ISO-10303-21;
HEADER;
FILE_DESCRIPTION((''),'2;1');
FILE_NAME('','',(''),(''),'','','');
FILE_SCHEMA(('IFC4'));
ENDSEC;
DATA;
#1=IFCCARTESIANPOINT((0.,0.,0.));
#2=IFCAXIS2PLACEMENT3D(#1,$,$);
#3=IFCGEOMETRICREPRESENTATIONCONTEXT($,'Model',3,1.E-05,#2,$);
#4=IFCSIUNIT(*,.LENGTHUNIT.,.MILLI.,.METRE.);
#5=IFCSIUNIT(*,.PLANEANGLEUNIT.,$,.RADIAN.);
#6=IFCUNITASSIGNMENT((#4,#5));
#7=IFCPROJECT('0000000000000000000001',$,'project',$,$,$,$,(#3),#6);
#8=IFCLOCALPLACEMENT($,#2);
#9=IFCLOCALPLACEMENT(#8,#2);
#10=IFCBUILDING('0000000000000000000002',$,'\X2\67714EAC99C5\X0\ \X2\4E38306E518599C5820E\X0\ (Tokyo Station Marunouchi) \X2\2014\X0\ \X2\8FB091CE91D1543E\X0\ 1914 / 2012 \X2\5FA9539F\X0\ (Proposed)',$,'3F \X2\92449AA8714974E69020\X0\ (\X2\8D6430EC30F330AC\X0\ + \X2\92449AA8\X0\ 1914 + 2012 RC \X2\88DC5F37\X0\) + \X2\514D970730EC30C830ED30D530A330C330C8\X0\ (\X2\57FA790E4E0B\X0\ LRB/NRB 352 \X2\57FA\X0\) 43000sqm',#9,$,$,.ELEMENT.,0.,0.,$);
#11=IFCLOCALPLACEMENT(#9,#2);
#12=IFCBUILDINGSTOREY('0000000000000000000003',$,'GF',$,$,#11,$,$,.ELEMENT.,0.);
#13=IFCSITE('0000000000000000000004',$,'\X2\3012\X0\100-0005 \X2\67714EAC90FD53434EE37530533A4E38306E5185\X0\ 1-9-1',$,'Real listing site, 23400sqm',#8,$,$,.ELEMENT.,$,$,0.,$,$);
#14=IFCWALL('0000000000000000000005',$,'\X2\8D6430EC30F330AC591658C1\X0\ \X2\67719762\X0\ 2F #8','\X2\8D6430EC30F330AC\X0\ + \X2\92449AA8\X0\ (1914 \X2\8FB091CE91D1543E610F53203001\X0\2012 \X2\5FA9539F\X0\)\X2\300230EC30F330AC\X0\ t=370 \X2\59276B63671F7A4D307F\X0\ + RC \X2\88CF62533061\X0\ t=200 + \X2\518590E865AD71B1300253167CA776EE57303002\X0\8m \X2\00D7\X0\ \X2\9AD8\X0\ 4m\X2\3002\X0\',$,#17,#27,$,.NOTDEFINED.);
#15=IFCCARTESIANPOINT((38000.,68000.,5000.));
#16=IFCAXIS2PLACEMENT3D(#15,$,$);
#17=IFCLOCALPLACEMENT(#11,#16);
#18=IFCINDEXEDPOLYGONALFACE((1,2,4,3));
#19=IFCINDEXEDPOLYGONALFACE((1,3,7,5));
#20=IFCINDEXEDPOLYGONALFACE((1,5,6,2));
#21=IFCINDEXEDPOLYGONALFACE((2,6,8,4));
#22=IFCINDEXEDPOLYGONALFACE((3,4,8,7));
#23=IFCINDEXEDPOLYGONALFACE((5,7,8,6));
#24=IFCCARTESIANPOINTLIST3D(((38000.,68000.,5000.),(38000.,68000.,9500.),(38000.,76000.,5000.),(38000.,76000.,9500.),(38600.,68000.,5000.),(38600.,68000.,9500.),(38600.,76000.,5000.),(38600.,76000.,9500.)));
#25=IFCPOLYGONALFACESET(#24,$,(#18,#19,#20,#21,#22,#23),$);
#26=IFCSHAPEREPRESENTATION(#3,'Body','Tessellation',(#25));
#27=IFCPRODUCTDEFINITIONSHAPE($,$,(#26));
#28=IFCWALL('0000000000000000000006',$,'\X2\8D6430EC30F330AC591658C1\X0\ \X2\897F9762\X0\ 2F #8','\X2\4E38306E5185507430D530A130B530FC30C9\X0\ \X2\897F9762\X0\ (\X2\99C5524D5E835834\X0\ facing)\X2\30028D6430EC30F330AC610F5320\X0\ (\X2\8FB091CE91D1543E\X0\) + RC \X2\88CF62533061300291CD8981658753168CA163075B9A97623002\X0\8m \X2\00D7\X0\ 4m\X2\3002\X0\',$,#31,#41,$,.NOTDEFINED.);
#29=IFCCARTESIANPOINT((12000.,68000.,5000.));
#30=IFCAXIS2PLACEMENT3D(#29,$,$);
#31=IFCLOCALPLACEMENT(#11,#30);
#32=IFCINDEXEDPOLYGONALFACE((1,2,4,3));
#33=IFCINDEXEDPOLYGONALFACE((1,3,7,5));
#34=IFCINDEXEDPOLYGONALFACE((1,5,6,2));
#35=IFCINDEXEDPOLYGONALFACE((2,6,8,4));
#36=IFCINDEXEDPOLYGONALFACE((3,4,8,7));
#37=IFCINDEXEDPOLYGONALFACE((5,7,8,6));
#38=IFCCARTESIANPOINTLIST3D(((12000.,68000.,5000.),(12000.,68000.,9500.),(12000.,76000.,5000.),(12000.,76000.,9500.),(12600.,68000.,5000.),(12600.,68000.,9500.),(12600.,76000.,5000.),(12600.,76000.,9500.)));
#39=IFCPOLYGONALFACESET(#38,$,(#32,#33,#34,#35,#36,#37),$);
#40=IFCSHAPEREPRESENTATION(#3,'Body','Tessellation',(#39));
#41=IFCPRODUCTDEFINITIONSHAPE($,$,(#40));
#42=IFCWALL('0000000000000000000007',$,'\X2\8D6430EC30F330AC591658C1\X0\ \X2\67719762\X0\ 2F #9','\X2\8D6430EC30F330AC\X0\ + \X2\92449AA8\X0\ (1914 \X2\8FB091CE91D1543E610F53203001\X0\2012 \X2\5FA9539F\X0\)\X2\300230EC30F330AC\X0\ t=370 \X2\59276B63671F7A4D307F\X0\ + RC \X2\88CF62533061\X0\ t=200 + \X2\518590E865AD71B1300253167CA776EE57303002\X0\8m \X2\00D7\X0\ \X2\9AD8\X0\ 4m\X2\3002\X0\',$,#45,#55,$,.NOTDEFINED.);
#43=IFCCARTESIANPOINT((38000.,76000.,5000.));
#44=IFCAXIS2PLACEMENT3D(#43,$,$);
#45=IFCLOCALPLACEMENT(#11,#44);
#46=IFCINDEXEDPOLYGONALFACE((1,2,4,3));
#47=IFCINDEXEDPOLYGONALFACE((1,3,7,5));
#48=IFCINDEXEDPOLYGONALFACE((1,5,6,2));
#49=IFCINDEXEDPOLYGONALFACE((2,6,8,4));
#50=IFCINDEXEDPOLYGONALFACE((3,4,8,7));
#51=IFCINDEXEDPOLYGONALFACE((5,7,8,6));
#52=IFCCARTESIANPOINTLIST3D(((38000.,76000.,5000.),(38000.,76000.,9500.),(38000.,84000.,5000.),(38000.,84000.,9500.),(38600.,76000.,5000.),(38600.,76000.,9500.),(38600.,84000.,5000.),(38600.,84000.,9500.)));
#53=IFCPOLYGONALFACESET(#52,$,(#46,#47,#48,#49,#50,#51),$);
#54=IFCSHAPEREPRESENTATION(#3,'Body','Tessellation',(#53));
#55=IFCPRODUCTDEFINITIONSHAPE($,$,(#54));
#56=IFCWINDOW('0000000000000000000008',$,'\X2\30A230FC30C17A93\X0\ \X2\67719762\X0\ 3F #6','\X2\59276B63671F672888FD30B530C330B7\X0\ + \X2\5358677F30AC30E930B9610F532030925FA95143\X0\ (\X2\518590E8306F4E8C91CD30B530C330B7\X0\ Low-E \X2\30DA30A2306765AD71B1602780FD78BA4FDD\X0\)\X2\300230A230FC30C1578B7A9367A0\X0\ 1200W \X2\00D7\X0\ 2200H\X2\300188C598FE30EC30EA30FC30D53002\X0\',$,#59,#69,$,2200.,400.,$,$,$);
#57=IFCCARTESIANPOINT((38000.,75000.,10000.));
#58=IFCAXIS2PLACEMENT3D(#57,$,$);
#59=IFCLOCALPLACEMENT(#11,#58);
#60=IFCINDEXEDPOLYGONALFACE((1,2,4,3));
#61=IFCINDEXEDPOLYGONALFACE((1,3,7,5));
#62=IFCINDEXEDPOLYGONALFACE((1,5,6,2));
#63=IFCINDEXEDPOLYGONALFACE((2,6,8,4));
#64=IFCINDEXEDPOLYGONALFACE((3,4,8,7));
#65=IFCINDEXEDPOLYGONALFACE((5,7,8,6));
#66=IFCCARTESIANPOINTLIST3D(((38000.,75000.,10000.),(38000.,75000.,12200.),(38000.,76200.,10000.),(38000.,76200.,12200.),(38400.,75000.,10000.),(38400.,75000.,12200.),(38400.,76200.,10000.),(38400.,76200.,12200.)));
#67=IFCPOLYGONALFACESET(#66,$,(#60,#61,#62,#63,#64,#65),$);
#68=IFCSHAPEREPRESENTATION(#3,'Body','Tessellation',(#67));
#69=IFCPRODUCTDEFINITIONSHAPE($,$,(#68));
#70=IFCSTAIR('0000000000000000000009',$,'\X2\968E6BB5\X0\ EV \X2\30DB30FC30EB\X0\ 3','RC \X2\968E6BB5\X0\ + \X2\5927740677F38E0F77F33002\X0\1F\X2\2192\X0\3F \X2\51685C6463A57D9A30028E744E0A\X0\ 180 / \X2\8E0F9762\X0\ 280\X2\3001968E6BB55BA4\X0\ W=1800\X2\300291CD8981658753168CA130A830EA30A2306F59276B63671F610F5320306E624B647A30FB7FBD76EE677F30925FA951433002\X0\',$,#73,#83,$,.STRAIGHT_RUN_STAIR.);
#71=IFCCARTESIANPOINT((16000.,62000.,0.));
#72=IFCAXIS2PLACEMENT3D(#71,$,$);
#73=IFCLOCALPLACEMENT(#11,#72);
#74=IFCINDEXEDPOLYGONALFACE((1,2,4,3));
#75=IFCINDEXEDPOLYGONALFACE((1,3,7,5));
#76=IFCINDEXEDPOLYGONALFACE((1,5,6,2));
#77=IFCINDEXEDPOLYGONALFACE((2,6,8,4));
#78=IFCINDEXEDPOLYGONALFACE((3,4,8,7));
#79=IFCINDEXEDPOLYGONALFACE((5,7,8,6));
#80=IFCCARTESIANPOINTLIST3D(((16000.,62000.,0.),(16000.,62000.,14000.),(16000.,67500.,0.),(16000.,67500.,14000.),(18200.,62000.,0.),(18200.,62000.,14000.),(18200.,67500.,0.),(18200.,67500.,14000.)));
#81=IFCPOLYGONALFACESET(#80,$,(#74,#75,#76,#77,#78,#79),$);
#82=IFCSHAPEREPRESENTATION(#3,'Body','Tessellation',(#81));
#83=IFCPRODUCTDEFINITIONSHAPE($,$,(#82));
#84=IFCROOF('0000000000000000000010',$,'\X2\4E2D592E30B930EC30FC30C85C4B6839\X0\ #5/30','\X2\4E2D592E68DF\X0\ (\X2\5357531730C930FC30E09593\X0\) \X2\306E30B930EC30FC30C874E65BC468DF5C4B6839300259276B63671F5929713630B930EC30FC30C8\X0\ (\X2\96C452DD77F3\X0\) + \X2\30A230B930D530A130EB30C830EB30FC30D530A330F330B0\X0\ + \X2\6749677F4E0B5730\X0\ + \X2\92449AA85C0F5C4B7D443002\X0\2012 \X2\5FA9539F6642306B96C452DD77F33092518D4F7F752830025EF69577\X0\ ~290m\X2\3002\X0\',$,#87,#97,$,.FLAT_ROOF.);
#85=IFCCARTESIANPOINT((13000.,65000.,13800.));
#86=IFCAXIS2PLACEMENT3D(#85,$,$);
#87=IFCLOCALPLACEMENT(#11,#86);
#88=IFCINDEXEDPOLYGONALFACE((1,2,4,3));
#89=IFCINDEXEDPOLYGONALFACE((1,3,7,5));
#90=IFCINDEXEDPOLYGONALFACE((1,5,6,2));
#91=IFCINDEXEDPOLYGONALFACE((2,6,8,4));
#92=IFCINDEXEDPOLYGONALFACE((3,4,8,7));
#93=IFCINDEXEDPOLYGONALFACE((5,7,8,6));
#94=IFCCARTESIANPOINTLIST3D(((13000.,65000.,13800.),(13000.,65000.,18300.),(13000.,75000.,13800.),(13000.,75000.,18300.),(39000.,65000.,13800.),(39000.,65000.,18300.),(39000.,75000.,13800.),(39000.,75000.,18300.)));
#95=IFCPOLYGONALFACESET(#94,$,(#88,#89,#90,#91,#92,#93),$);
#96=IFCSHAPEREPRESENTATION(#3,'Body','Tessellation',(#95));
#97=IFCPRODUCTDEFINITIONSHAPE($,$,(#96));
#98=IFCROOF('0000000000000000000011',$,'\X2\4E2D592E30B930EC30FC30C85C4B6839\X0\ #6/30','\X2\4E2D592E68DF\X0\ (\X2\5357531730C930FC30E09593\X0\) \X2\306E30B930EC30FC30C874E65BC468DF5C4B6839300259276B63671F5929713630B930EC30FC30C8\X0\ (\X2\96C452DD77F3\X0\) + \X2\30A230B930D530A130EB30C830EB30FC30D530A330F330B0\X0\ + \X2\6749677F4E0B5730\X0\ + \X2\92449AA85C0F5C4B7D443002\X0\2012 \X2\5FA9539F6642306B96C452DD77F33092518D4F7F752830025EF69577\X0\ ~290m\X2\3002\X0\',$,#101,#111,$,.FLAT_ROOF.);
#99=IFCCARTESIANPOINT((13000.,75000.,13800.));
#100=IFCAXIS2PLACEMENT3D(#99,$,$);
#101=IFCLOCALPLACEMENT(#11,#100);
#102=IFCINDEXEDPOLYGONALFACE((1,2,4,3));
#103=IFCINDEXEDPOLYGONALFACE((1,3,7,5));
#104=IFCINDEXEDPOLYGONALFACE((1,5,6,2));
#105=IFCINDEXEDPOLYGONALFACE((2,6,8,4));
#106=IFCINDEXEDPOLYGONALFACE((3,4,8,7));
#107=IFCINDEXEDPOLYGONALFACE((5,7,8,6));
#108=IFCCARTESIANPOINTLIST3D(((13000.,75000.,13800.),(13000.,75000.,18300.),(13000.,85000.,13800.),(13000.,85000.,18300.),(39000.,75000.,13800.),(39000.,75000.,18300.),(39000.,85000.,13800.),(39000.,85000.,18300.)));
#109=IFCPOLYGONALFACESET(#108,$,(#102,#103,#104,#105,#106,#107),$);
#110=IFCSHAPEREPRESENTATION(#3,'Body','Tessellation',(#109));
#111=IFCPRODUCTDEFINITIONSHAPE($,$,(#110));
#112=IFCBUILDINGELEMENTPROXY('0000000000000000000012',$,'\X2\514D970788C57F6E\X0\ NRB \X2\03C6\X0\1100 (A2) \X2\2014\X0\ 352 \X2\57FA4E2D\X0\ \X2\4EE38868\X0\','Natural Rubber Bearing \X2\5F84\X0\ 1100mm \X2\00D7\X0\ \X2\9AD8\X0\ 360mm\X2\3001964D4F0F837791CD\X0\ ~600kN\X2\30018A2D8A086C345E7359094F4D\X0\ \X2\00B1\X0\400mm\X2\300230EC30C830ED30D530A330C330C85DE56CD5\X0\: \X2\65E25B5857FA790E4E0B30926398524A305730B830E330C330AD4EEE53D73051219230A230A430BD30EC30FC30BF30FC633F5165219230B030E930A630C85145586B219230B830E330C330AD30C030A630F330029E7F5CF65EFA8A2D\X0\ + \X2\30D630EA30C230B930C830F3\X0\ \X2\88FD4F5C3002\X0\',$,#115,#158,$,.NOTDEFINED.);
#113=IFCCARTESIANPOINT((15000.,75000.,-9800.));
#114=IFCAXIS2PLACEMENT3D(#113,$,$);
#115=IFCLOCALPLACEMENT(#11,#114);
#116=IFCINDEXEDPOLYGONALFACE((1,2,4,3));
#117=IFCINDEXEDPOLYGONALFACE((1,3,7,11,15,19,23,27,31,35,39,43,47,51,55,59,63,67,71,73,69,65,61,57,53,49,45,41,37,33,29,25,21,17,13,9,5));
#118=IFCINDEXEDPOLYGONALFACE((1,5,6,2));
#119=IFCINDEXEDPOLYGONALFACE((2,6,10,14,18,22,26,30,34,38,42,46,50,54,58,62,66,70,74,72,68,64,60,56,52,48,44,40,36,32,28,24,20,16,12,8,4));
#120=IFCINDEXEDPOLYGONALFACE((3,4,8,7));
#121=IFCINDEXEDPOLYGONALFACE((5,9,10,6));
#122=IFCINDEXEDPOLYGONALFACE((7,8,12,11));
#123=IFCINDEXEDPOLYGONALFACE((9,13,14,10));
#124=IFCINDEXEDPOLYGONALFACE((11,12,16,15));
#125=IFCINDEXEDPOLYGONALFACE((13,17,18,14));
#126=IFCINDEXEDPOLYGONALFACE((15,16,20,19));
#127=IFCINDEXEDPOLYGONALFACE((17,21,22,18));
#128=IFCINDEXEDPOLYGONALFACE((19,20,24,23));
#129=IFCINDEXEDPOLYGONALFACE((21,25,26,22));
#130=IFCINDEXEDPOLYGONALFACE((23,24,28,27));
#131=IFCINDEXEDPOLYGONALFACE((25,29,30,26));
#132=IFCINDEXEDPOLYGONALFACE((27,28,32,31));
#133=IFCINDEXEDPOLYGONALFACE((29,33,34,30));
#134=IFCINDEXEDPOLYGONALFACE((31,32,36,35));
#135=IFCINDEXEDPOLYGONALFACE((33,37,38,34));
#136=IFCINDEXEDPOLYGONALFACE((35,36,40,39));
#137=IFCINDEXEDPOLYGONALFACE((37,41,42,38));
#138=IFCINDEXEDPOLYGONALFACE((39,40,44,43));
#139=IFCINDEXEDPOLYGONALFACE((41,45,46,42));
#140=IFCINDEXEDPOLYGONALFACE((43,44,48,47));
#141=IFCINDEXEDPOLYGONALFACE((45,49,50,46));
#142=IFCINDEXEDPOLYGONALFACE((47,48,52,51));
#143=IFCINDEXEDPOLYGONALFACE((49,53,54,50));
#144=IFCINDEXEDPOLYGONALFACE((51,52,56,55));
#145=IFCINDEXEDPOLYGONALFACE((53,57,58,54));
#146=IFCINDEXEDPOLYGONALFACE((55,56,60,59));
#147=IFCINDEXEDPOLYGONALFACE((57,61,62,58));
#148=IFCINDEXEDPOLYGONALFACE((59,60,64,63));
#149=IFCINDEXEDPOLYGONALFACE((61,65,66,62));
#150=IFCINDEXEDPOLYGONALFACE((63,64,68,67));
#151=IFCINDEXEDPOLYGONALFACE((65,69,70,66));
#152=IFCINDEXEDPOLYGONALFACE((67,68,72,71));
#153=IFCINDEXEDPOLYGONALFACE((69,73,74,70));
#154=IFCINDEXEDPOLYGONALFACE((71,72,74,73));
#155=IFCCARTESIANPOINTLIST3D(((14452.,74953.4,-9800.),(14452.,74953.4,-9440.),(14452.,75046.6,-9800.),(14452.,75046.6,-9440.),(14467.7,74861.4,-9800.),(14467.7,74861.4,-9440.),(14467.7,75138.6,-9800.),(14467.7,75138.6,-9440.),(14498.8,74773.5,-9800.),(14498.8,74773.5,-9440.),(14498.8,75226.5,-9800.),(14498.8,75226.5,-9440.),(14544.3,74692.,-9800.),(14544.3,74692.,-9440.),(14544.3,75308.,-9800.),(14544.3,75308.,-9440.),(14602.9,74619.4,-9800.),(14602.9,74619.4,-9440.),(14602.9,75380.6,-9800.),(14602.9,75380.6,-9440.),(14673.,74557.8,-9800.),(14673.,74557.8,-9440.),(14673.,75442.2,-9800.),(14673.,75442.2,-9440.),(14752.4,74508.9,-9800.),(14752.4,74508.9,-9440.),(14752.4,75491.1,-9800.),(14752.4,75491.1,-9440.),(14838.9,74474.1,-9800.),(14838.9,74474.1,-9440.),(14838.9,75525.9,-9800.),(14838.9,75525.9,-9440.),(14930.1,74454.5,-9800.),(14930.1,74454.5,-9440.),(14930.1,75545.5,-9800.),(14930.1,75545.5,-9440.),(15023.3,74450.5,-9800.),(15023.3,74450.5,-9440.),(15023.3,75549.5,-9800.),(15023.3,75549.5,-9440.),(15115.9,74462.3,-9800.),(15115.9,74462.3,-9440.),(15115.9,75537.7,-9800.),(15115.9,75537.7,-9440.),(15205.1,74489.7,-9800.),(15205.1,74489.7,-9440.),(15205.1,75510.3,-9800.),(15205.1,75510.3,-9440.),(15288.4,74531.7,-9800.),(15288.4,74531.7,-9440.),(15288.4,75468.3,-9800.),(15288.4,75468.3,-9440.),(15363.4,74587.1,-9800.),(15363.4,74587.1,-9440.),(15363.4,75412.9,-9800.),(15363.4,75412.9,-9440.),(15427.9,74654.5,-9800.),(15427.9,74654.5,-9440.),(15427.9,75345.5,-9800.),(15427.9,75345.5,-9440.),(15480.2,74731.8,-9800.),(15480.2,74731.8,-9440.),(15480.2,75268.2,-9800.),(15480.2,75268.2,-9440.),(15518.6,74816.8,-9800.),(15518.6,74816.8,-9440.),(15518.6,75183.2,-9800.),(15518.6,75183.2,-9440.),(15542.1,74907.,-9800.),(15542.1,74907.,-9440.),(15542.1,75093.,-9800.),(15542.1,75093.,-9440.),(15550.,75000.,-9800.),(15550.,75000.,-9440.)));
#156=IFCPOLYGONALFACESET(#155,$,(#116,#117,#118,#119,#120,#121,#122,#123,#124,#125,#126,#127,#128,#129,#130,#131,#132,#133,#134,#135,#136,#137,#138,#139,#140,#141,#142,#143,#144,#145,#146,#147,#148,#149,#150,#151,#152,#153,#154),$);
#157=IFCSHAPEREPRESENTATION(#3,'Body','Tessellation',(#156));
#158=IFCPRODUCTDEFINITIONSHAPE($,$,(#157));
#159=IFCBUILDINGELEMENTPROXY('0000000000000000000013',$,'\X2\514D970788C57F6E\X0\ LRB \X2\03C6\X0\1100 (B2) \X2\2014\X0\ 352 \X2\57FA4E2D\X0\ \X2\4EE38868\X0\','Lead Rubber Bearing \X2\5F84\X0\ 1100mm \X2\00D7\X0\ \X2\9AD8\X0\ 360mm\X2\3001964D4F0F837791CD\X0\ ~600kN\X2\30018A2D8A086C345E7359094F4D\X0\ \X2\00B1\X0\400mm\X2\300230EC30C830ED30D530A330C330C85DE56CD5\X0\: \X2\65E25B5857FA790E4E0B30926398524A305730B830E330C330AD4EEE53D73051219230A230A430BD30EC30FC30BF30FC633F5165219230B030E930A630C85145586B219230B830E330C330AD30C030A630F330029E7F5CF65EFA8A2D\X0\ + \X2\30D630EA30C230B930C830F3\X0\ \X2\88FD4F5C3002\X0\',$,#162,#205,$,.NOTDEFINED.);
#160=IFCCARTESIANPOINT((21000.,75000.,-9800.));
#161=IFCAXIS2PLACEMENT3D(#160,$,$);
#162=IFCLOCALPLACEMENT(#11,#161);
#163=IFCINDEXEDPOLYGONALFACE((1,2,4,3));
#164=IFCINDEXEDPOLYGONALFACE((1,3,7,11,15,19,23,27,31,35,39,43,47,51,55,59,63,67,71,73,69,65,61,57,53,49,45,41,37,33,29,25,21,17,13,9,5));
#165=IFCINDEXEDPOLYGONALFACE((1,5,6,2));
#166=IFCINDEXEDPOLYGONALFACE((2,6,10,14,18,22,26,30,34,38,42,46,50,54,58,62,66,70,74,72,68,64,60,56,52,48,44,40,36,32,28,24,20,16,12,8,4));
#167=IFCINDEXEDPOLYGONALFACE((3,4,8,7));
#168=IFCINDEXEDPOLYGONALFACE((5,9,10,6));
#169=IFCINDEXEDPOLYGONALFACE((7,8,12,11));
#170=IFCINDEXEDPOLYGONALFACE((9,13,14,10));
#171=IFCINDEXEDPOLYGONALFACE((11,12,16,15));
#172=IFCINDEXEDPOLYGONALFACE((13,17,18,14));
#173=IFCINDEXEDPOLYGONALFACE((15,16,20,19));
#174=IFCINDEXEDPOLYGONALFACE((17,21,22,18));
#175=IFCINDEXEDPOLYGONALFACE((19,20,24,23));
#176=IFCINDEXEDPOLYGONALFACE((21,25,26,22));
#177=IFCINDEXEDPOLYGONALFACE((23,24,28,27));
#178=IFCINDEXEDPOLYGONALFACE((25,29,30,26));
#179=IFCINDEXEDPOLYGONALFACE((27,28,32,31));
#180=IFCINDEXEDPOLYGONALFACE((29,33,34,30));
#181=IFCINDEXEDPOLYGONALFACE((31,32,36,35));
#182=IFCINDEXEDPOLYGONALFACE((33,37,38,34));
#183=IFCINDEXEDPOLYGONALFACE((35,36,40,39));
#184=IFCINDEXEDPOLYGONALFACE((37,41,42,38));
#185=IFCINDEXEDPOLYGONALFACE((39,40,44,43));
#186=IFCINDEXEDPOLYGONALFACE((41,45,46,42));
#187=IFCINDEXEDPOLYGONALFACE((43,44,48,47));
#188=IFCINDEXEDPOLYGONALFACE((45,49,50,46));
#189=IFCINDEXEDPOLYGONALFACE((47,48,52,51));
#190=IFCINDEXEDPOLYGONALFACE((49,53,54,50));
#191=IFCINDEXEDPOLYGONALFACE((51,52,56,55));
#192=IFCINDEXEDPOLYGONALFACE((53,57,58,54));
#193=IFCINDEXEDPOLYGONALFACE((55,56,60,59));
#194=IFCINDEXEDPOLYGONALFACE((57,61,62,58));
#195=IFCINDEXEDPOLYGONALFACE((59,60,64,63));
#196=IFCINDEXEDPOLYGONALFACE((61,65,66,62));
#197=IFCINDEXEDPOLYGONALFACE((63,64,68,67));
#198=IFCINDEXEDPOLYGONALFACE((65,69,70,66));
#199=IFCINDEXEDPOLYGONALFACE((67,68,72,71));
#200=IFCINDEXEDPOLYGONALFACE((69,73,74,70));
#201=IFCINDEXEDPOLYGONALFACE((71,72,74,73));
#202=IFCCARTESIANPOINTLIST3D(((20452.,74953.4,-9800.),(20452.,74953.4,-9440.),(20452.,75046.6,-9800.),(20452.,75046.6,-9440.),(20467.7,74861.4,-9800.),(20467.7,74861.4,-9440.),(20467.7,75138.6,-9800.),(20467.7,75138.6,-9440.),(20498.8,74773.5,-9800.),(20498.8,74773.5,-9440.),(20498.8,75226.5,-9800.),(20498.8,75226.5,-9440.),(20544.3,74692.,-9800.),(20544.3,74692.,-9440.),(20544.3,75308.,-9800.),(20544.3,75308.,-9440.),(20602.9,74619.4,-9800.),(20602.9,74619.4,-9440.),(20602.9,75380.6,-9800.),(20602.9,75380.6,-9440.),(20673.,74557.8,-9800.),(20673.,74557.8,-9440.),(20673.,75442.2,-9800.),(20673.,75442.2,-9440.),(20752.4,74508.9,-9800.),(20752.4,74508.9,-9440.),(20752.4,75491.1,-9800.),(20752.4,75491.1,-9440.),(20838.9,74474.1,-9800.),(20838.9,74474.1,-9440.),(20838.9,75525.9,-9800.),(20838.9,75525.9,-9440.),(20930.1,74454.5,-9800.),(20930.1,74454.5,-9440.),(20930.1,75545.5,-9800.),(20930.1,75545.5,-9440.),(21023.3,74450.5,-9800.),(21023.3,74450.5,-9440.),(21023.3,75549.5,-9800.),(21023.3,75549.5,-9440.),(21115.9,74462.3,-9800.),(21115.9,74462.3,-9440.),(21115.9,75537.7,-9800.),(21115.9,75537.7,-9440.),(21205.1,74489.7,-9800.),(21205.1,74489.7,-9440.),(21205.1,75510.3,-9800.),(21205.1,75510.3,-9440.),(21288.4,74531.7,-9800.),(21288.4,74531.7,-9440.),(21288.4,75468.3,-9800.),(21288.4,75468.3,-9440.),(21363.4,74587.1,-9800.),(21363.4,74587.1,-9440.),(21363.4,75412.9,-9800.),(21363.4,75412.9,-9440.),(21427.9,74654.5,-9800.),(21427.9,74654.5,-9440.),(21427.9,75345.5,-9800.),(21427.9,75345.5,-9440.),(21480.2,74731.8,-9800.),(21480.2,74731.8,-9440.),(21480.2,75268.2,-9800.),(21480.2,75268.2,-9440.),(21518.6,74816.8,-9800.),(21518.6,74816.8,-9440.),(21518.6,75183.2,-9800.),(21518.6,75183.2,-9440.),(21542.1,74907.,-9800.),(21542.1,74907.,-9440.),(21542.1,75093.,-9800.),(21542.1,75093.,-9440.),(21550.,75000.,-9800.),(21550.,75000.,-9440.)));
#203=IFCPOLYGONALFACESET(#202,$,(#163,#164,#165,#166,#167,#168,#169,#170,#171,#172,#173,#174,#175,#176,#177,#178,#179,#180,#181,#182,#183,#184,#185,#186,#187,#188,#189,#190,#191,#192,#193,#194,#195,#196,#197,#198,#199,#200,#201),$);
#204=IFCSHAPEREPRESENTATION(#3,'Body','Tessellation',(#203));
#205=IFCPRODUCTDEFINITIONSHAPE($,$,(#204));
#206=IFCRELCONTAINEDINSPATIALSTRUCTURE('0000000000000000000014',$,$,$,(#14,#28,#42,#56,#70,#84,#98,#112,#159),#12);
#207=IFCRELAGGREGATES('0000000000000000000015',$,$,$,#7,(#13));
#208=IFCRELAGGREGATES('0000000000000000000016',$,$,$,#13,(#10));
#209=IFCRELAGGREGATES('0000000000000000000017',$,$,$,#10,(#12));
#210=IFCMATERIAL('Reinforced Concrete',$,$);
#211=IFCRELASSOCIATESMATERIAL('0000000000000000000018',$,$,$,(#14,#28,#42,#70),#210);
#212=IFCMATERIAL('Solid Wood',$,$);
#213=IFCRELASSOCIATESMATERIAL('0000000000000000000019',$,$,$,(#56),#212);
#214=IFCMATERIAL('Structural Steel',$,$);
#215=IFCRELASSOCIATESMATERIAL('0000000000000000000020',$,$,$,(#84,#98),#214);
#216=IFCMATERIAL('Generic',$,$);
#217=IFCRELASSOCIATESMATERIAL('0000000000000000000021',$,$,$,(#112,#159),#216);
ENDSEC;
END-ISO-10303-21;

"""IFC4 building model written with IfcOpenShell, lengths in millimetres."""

from ifc_helpers import new_model, si_unit, frame, frame_2d, origin, origin_2d, place, context, project, spatial, rectangle, circle, extrude, material, element, save


model = new_model("IFC4")

# Units and contexts
model_context = context("Model", 3, precision=1e-05, world=origin())
ifc_project = project(units=[si_unit("LENGTHUNIT", "METRE", prefix="MILLI"), si_unit("PLANEANGLEUNIT", "RADIAN")], contexts=[model_context])

# Site, building, storey
site_placement = place(None, origin())
site = spatial("IfcSite", under=ifc_project, at=site_placement, Name="〒100-0005 東京都千代田区丸の内 1-9-1", ObjectType="Real listing site, 23400sqm", CompositionType="ELEMENT", RefElevation=0.0)
building_placement = place(site_placement, origin())
building = spatial("IfcBuilding", under=site, at=building_placement, Name="東京駅 丸の内駅舎 (Tokyo Station Marunouchi) — 辰野金吾 1914 / 2012 復原 (Proposed)", ObjectType="3F 鉄骨煉瓦造 (赤レンガ + 鉄骨 1914 + 2012 RC 補強) + 免震レトロフィット (基礎下 LRB/NRB 352 基) 43000sqm", CompositionType="ELEMENT", ElevationOfRefHeight=0.0, ElevationOfTerrain=0.0)
storey_placement = place(building_placement, origin())
storey = spatial("IfcBuildingStorey", under=building, at=storey_placement, Name="GF", CompositionType="ELEMENT", Elevation=0.0)

# Shared definitions
ifc_material_1 = material(Name="Reinforced Concrete")

# Shared definitions
ifc_material_2 = material(Name="Structural Steel")

# Shared definitions
ifc_material_3 = material(Name="Solid Wood")

# Walls
wall_1_placement = place(storey_placement, frame((38000.0, 68000.0, 5000.0)))
element("IfcWall", 1, at=wall_1_placement, inside=storey, material=ifc_material_1, Name="赤レンガ外壁 東面 2F #8", Description="赤レンガ + 鉄骨 (1914 辰野金吾意匠、2012 復原)。レンガ t=370 大正期積み + RC 裏打ち t=200 + 内部断熱。化粧目地。8m × 高 4m。", PredefinedType="NOTDEFINED", context=model_context, shape_type="SweptSolid", body=[
    extrude(rectangle(XDim=600.0, YDim=8000.0, at=frame_2d((300.0, 4000.0))), frame((38000.0, 68000.0, 5000.0)), (0.0, 0.0, 1.0), 4500.0),
])
wall_2_placement = place(storey_placement, frame((12000.0, 68000.0, 5000.0)))
element("IfcWall", 2, at=wall_2_placement, inside=storey, material=ifc_material_1, Name="赤レンガ外壁 西面 2F #8", Description="丸の内側ファサード 西面 (駅前広場 facing)。赤レンガ意匠 (辰野金吾) + RC 裏打ち。重要文化財指定面。8m × 4m。", PredefinedType="NOTDEFINED", context=model_context, shape_type="SweptSolid", body=[
    extrude(rectangle(XDim=600.0, YDim=8000.0, at=frame_2d((300.0, 4000.0))), frame((12000.0, 68000.0, 5000.0)), (0.0, 0.0, 1.0), 4500.0),
])
wall_3_placement = place(storey_placement, frame((38000.0, 76000.0, 5000.0)))
element("IfcWall", 3, at=wall_3_placement, inside=storey, material=ifc_material_1, Name="赤レンガ外壁 東面 2F #9", Description="赤レンガ + 鉄骨 (1914 辰野金吾意匠、2012 復原)。レンガ t=370 大正期積み + RC 裏打ち t=200 + 内部断熱。化粧目地。8m × 高 4m。", PredefinedType="NOTDEFINED", context=model_context, shape_type="SweptSolid", body=[
    extrude(rectangle(XDim=600.0, YDim=8000.0, at=frame_2d((300.0, 4000.0))), frame((38000.0, 76000.0, 5000.0)), (0.0, 0.0, 1.0), 4500.0),
])

# Window
window_1_placement = place(storey_placement, frame((38000.0, 75000.0, 10000.0)))
element("IfcWindow", 4, at=window_1_placement, inside=storey, material=ifc_material_3, Name="アーチ窓 東面 3F #6", Description="大正期木製サッシ + 単板ガラス意匠を復元 (内部は二重サッシ Low-E ペアで断熱性能確保)。アーチ型窓枠 1200W × 2200H、装飾レリーフ。", OverallHeight=2200.0, OverallWidth=400.0, context=model_context, shape_type="SweptSolid", body=[
    extrude(rectangle(XDim=400.0, YDim=1200.0, at=frame_2d((200.0, 600.0))), frame((38000.0, 75000.0, 10000.0)), (0.0, 0.0, 1.0), 2200.0),
])

# Stair
stair_placement = place(storey_placement, frame((16000.0, 62000.0, 0.0)))
element("IfcStair", 5, at=stair_placement, inside=storey, material=ifc_material_1, Name="階段 EV ホール 3", Description="RC 階段 + 大理石踏石。1F→3F 全層接続。蹴上 180 / 踏面 280、階段室 W=1800。重要文化財エリアは大正期意匠の手摺・羽目板を復元。", PredefinedType="STRAIGHT_RUN_STAIR", context=model_context, shape_type="SweptSolid", body=[
    extrude(rectangle(XDim=2200.0, YDim=5500.0, at=frame_2d((1100.0, 2750.0))), frame((16000.0, 62000.0, 0.0)), (0.0, 0.0, 1.0), 14000.0),
])

# Roofs
roof_1_placement = place(storey_placement, frame((13000.0, 65000.0, 13800.0)))
element("IfcRoof", 6, at=roof_1_placement, inside=storey, material=ifc_material_2, Name="中央スレート屋根 #5/30", Description="中央棟 (南北ドーム間) のスレート瓦寄棟屋根。大正期天然スレート (雄勝石) + アスファルトルーフィング + 杉板下地 + 鉄骨小屋組。2012 復原時に雄勝石を再使用。延長 ~290m。", PredefinedType="FLAT_ROOF", context=model_context, shape_type="SweptSolid", body=[
    extrude(rectangle(XDim=26000.0, YDim=10000.0, at=frame_2d((13000.0, 5000.0))), frame((13000.0, 65000.0, 13800.0)), (0.0, 0.0, 1.0), 4500.0),
])
roof_2_placement = place(storey_placement, frame((13000.0, 75000.0, 13800.0)))
element("IfcRoof", 7, at=roof_2_placement, inside=storey, material=ifc_material_2, Name="中央スレート屋根 #6/30", Description="中央棟 (南北ドーム間) のスレート瓦寄棟屋根。大正期天然スレート (雄勝石) + アスファルトルーフィング + 杉板下地 + 鉄骨小屋組。2012 復原時に雄勝石を再使用。延長 ~290m。", PredefinedType="FLAT_ROOF", context=model_context, shape_type="SweptSolid", body=[
    extrude(rectangle(XDim=26000.0, YDim=10000.0, at=frame_2d((13000.0, 5000.0))), frame((13000.0, 75000.0, 13800.0)), (0.0, 0.0, 1.0), 4500.0),
])

# Building element proxies
ifc_material_4 = material(Name="Generic")
proxy_1_placement = place(storey_placement, frame((15000.0, 75000.0, -9800.0)))
element("IfcBuildingElementProxy", 8, at=proxy_1_placement, inside=storey, material=ifc_material_4, Name="免震装置 NRB φ1100 (A2) — 352 基中 代表", Description="Natural Rubber Bearing 径 1100mm × 高 360mm、降伏荷重 ~600kN、設計水平変位 ±400mm。レトロフィット工法: 既存基礎下を掘削しジャッキ仮受け→アイソレーター挿入→グラウト充填→ジャッキダウン。鹿島建設 + ブリヂストン 製作。", PredefinedType="NOTDEFINED", context=model_context, shape_type="SweptSolid", body=[
    extrude(circle(Radius=550.0, at=origin_2d()), frame((15000.0, 75000.0, -9800.0)), (0.0, 0.0, 1.0), 360.0),
])
proxy_2_placement = place(storey_placement, frame((21000.0, 75000.0, -9800.0)))
element("IfcBuildingElementProxy", 9, at=proxy_2_placement, inside=storey, material=ifc_material_4, Name="免震装置 LRB φ1100 (B2) — 352 基中 代表", Description="Lead Rubber Bearing 径 1100mm × 高 360mm、降伏荷重 ~600kN、設計水平変位 ±400mm。レトロフィット工法: 既存基礎下を掘削しジャッキ仮受け→アイソレーター挿入→グラウト充填→ジャッキダウン。鹿島建設 + ブリヂストン 製作。", PredefinedType="NOTDEFINED", context=model_context, shape_type="SweptSolid", body=[
    extrude(circle(Radius=550.0, at=origin_2d()), frame((21000.0, 75000.0, -9800.0)), (0.0, 0.0, 1.0), 360.0),
])

save(model, "model.ifc")
